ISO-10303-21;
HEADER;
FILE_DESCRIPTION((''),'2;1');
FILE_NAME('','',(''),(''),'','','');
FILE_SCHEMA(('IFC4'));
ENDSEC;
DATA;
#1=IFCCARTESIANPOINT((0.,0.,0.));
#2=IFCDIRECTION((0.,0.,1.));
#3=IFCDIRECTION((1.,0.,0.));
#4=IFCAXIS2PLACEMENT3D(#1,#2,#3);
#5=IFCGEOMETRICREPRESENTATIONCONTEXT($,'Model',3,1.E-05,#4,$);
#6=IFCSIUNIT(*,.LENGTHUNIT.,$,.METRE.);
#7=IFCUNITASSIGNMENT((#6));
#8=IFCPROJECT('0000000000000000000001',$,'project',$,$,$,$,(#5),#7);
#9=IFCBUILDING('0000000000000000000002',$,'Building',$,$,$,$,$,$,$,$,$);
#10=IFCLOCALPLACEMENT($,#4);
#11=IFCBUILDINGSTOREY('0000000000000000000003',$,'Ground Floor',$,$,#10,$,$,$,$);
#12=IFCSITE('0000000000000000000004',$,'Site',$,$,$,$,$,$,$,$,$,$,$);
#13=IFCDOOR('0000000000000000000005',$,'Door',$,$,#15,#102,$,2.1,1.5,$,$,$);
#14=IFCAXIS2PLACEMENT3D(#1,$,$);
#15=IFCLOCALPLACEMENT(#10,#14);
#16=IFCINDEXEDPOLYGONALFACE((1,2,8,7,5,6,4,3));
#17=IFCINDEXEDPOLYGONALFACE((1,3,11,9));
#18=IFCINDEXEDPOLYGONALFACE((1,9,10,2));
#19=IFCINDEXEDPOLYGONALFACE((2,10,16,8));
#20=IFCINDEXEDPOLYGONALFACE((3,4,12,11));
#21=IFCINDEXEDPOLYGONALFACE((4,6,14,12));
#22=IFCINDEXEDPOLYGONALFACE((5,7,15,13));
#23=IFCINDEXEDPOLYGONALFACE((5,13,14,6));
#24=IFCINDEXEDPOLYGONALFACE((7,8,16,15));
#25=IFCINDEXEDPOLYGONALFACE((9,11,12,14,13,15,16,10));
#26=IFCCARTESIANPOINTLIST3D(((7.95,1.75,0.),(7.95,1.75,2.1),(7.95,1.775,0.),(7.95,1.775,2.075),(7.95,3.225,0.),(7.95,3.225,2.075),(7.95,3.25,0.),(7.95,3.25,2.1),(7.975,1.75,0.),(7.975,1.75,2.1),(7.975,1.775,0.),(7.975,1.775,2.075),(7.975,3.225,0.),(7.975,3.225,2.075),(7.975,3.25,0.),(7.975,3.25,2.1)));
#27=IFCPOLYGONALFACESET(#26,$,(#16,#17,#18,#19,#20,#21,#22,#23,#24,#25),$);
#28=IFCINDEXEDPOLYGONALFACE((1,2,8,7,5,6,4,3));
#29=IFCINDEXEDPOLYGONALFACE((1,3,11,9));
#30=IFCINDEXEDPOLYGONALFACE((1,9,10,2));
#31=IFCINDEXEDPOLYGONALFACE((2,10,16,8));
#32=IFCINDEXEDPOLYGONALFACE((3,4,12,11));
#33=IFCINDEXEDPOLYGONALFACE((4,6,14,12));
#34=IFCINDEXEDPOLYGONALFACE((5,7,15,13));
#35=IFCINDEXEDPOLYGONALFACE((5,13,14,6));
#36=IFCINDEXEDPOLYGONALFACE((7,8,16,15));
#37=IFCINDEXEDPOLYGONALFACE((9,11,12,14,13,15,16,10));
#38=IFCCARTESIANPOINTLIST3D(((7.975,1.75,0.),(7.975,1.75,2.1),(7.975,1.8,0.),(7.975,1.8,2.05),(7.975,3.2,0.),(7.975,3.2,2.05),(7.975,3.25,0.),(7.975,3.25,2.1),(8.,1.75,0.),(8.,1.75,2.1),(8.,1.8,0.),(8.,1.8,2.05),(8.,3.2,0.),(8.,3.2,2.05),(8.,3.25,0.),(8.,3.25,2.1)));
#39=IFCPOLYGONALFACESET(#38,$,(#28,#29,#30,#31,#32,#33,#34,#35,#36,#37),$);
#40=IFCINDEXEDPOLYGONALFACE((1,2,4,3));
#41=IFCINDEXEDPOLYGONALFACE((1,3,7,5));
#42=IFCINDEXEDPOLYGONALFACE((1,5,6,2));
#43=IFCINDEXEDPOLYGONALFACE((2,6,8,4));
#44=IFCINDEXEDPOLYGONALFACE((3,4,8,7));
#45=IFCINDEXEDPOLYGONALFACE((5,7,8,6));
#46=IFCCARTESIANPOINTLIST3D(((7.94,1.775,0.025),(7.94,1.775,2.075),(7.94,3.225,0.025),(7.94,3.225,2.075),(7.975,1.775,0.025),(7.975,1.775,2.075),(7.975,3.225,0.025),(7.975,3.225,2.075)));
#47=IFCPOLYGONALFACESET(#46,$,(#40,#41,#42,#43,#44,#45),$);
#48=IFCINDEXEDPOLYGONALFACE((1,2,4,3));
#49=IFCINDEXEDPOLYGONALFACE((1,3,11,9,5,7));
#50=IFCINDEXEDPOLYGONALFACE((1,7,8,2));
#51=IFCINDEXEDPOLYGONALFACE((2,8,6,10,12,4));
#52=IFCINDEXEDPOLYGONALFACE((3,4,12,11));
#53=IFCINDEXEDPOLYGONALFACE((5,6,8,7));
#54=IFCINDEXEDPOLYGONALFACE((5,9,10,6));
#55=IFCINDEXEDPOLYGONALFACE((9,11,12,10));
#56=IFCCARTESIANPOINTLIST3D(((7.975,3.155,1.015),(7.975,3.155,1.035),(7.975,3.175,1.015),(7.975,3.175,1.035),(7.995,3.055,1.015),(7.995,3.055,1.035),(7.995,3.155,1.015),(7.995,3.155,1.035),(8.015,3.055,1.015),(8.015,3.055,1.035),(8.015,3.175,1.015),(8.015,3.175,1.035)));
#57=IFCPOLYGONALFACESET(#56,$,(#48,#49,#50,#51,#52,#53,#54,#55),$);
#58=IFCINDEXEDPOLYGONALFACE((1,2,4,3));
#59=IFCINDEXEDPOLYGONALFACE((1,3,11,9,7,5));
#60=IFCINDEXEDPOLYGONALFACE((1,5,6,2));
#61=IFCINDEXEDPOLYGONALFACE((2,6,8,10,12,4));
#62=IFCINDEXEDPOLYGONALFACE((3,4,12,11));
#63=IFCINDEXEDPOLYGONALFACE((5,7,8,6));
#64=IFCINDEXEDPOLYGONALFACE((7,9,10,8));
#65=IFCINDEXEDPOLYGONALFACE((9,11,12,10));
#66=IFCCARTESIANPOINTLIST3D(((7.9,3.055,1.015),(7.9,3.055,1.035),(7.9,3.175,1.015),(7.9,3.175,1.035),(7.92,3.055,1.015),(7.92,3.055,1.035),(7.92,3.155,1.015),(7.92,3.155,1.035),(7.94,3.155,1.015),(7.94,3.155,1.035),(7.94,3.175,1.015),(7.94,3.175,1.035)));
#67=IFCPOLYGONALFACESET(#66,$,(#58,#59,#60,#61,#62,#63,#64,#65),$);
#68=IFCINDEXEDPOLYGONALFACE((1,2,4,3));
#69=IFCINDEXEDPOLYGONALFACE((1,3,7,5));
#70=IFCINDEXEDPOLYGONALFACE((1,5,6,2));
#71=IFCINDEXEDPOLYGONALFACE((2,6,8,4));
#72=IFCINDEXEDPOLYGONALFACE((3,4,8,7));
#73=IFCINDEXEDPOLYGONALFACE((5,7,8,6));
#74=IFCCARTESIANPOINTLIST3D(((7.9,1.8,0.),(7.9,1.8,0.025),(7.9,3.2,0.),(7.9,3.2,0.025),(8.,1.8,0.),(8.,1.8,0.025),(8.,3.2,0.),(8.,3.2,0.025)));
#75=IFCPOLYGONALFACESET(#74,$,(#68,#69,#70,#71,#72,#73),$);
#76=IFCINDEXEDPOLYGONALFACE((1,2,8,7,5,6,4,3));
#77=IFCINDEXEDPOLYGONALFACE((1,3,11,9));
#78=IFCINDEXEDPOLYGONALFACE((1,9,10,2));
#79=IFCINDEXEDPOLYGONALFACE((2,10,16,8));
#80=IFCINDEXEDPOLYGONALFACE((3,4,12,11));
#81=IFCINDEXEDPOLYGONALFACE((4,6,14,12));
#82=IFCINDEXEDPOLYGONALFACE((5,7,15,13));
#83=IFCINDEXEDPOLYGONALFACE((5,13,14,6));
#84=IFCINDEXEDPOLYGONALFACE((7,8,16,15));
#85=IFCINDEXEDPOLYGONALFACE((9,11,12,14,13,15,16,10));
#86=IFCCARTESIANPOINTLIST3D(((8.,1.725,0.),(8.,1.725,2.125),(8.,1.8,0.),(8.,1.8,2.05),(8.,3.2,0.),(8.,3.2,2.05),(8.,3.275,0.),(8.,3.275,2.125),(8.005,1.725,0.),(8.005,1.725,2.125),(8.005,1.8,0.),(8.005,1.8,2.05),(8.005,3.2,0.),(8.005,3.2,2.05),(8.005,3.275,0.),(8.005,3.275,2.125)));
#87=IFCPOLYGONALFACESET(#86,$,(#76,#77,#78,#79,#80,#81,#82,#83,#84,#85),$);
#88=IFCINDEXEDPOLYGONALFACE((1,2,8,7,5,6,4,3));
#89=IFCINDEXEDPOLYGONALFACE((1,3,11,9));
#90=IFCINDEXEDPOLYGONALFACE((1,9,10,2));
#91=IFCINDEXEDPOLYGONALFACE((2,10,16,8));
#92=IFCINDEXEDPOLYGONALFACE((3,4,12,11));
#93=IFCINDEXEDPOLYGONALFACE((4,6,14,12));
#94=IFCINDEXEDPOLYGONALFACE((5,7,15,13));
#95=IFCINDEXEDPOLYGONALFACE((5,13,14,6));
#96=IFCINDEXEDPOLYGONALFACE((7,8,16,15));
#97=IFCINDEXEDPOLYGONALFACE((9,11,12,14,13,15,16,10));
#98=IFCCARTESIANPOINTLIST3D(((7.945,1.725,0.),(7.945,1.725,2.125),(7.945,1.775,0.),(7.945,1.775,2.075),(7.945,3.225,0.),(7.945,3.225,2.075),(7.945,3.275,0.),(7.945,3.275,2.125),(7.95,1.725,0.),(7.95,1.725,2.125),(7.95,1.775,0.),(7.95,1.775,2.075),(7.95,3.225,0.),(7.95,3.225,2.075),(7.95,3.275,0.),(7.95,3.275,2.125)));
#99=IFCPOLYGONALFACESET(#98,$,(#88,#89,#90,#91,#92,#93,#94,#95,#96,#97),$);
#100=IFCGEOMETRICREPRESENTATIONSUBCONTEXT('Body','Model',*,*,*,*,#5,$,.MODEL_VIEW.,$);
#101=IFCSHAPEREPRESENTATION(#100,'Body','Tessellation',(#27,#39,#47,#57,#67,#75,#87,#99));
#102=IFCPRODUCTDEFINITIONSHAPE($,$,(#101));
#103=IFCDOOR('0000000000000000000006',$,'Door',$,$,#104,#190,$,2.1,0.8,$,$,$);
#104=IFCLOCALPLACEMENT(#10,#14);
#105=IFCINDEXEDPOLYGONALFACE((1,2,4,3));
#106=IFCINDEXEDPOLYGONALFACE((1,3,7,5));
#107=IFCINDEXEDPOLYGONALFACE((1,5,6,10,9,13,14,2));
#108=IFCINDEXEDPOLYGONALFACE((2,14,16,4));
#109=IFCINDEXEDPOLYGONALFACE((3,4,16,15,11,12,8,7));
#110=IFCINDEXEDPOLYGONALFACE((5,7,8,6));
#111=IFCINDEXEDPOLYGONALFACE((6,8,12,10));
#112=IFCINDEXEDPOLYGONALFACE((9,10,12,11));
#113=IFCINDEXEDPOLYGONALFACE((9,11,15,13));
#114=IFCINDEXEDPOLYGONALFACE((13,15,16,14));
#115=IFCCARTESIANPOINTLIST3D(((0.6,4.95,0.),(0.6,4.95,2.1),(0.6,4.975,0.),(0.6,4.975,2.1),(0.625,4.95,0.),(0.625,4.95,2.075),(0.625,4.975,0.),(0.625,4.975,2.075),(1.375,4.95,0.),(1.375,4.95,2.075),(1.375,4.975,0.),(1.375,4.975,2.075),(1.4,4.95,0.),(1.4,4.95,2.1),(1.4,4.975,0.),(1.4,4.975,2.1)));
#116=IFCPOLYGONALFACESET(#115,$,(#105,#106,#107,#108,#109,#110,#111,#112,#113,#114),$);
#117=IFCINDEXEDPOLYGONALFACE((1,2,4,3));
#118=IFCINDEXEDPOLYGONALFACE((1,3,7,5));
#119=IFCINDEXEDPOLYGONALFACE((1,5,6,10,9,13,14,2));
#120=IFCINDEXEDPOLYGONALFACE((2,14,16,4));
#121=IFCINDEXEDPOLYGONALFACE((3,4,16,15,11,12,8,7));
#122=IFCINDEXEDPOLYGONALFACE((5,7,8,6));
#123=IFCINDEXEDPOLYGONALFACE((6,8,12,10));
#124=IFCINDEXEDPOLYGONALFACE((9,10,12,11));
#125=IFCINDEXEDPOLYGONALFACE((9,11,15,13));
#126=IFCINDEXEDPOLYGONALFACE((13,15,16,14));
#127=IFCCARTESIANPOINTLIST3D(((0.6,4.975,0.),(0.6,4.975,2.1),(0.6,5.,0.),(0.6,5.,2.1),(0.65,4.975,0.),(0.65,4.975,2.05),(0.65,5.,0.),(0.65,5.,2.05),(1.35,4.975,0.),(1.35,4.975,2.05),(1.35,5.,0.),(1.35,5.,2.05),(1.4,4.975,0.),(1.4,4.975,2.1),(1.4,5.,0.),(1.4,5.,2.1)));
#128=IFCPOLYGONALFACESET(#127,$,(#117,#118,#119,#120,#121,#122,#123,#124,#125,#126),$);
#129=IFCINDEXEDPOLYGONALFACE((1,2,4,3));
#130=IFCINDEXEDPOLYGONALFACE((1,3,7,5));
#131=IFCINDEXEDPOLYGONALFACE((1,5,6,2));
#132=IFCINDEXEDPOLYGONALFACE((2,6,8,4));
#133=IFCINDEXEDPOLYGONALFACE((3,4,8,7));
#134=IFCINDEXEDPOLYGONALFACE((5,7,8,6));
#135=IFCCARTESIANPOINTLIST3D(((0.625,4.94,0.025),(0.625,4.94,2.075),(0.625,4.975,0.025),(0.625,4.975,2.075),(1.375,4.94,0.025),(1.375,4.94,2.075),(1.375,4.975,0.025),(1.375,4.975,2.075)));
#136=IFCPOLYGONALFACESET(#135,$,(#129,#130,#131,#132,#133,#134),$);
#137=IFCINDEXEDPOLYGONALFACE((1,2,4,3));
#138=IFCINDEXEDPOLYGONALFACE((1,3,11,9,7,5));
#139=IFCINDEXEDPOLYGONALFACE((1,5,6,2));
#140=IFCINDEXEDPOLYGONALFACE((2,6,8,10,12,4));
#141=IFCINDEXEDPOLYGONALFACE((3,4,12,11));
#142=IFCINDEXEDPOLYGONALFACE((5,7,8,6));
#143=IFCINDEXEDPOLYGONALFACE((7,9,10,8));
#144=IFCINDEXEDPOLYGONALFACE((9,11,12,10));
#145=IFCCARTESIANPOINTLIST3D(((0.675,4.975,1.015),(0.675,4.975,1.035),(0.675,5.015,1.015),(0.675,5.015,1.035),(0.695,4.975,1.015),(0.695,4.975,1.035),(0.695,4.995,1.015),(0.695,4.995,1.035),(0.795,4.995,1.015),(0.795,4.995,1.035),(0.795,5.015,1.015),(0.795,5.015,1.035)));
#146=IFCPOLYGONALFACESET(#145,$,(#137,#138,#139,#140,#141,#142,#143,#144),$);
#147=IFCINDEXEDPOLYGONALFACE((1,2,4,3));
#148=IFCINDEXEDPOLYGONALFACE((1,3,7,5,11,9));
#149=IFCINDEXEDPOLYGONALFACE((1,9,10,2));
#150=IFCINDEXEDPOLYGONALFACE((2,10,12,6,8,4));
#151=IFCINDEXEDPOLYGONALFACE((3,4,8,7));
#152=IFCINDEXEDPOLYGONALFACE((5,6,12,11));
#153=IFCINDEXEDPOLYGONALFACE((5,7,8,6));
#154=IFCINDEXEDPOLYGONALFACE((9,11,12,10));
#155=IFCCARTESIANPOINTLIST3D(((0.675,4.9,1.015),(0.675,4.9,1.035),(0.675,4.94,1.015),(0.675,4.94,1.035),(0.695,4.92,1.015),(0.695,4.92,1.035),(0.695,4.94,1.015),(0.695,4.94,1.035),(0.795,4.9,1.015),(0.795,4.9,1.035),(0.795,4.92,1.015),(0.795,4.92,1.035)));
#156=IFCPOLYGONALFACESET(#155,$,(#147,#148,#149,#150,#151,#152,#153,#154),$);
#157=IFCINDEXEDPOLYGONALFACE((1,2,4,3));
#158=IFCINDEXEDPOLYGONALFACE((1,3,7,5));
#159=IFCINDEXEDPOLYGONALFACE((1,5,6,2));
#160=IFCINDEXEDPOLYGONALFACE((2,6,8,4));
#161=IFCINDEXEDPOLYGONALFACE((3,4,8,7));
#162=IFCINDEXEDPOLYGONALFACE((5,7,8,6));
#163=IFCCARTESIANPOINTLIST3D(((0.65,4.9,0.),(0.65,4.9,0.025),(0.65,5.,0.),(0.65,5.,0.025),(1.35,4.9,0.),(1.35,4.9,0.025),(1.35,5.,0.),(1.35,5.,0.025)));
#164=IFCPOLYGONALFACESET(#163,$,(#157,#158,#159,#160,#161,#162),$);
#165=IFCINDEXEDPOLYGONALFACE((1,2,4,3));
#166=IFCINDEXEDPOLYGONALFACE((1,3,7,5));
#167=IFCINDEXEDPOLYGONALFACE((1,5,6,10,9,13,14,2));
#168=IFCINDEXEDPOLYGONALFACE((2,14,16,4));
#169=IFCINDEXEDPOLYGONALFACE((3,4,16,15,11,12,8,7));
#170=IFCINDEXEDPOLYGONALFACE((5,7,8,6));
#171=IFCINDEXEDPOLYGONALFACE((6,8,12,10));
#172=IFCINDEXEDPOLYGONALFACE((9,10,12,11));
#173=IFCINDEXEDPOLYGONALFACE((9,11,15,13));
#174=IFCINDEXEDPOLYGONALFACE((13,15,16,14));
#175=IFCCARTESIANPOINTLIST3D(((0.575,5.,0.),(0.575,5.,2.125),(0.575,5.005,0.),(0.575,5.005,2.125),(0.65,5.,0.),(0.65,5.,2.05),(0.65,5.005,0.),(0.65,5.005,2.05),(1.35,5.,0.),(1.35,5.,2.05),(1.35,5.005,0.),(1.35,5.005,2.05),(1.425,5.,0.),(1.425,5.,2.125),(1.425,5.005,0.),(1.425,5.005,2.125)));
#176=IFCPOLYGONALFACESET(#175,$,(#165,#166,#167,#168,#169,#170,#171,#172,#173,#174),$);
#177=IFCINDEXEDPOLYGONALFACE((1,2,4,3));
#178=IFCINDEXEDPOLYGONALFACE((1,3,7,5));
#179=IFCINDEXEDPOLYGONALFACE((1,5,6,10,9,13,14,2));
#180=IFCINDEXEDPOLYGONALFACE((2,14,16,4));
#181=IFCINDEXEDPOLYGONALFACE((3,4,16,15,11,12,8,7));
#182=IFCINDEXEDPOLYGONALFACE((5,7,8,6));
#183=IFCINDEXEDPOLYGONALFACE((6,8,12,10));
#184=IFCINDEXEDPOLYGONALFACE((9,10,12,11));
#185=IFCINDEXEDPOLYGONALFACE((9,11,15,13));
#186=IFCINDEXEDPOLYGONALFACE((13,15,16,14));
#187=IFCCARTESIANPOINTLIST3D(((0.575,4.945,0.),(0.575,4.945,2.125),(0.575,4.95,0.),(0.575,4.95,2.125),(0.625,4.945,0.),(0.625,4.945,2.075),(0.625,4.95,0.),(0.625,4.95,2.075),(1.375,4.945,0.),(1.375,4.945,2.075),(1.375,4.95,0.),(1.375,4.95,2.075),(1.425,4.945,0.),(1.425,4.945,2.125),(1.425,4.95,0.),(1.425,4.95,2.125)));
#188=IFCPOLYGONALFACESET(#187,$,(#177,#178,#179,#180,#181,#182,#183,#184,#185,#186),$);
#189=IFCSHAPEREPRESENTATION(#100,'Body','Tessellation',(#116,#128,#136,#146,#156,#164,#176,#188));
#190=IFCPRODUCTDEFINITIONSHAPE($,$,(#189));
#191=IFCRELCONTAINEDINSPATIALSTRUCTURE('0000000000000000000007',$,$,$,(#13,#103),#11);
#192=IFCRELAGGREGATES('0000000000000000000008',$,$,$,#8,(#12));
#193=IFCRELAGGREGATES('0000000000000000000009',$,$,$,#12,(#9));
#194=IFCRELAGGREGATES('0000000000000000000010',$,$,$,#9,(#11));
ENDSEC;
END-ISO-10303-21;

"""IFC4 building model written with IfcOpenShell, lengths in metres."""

from ifc_helpers import new_model, si_unit, frame, origin_with_axes, place, context, subcontext, project, spatial, line, indexed_curve, outline, extrude, element, save


model = new_model("IFC4")

# Units and contexts
model_context = context("Model", 3, precision=1e-05, world=origin_with_axes())
body_context = subcontext(model_context, "Body", "Model", "MODEL_VIEW")
ifc_project = project(units=[si_unit("LENGTHUNIT", "METRE")], contexts=[model_context])

# Site, building, storey
site = spatial("IfcSite", under=ifc_project, Name="Site")
building = spatial("IfcBuilding", under=site, Name="Building")
storey_placement = place(None, origin_with_axes())
storey = spatial("IfcBuildingStorey", under=building, at=storey_placement, Name="Ground Floor")

# Doors
door_1_placement = place(storey_placement, frame((8.0, 1.75, 0.0), z_axis=(0.0, 0.0, 1.0), x_axis=(0.0, 1.0, 0.0)))
element("IfcDoor", 1, at=door_1_placement, inside=storey, Name="Door", OverallHeight=2.1, OverallWidth=1.5, context=body_context, shape_type="SweptSolid", body=[
    extrude(outline(indexed_curve([(0.0, 0.0), (0.0, 2.1), (1.5, 2.1), (1.5, 0.0), (1.475, 0.0), (1.475, 2.075), (0.025, 2.075), (0.025, 0.0)], segments=[line(1, 2, 3, 4, 5, 6, 7, 8, 1)])), frame((0.0, 0.025, 0.0), z_axis=(0.0, -1.0, 0.0), x_axis=(1.0, 0.0, 0.0)), (0.0, 0.0, -1.0), 0.025),
    extrude(outline(indexed_curve([(0.0, 0.0), (0.0, 2.1), (1.5, 2.1), (1.5, 0.0), (1.45, 0.0), (1.45, 2.05), (0.05, 2.05), (0.05, 0.0)], segments=[line(1, 2, 3, 4, 5, 6, 7, 8, 1)])), frame((0.0, 0.0, 0.0), z_axis=(0.0, -1.0, 0.0), x_axis=(1.0, 0.0, 0.0)), (0.0, 0.0, -1.0), 0.025),
    extrude(outline(indexed_curve([(0.0, 0.0), (1.45, 0.0), (1.45, 0.035), (0.0, 0.035)], segments=[line(1, 2, 3, 4, 1)])), frame((0.025, 0.025, 0.025), z_axis=(0.0, 0.0, 1.0), x_axis=(1.0, 0.0, 0.0)), (0.0, 0.0, 1.0), 2.05),
    extrude(outline(indexed_curve([(0.0, 0.0), (0.0, -0.04), (-0.12, -0.04), (-0.12, -0.02), (-0.02, -0.02), (-0.02, 0.0)], segments=[line(1, 2, 3, 4, 5, 6, 1)])), frame((1.425, 0.025, 1.015), z_axis=(0.0, 0.0, 1.0), x_axis=(1.0, 0.0, 0.0)), (0.0, 0.0, 1.0), 0.02),
    extrude(outline(indexed_curve([(0.0, 0.0), (0.0, 0.04), (-0.12, 0.04), (-0.12, 0.02), (-0.02, 0.02), (-0.02, 0.0)], segments=[line(1, 2, 3, 4, 5, 6, 1)])), frame((1.425, 0.06, 1.015), z_axis=(0.0, 0.0, 1.0), x_axis=(1.0, 0.0, 0.0)), (0.0, 0.0, 1.0), 0.02),
    extrude(outline(indexed_curve([(0.0, 0.0), (1.4, 0.0), (1.4, 0.1), (0.0, 0.1)], segments=[line(1, 2, 3, 4, 1)])), frame((0.05, 0.0, 0.0), z_axis=(0.0, 0.0, 1.0), x_axis=(1.0, 0.0, 0.0)), (0.0, 0.0, 1.0), 0.025),
    extrude(outline(indexed_curve([(0.0, 0.0), (0.0, 2.125), (1.55, 2.125), (1.55, 0.0), (1.475, 0.0), (1.475, 2.05), (0.075, 2.05), (0.075, 0.0)], segments=[line(1, 2, 3, 4, 5, 6, 7, 8, 1)])), frame((-0.025, -0.005, 0.0), z_axis=(0.0, -1.0, 0.0), x_axis=(1.0, 0.0, 0.0)), (0.0, 0.0, -1.0), 0.005),
    extrude(outline(indexed_curve([(0.0, 0.0), (0.0, 2.125), (1.55, 2.125), (1.55, 0.0), (1.5, 0.0), (1.5, 2.075), (0.05, 2.075), (0.05, 0.0)], segments=[line(1, 2, 3, 4, 5, 6, 7, 8, 1)])), frame((-0.025, 0.05, 0.0), z_axis=(0.0, -1.0, 0.0), x_axis=(1.0, 0.0, 0.0)), (0.0, 0.0, -1.0), 0.005),
])
door_2_placement = place(storey_placement, frame((1.4, 5.0, 0.0), z_axis=(0.0, 0.0, 1.0), x_axis=(-1.0, 0.0, 0.0)))
element("IfcDoor", 2, at=door_2_placement, inside=storey, Name="Door", OverallHeight=2.1, OverallWidth=0.8, context=body_context, shape_type="SweptSolid", body=[
    extrude(outline(indexed_curve([(0.0, 0.0), (0.0, 2.1), (0.8, 2.1), (0.8, 0.0), (0.775, 0.0), (0.775, 2.075), (0.025, 2.075), (0.025, 0.0)], segments=[line(1, 2, 3, 4, 5, 6, 7, 8, 1)])), frame((0.0, 0.025, 0.0), z_axis=(0.0, -1.0, 0.0), x_axis=(1.0, 0.0, 0.0)), (0.0, 0.0, -1.0), 0.025),
    extrude(outline(indexed_curve([(0.0, 0.0), (0.0, 2.1), (0.8, 2.1), (0.8, 0.0), (0.75, 0.0), (0.75, 2.05), (0.05, 2.05), (0.05, 0.0)], segments=[line(1, 2, 3, 4, 5, 6, 7, 8, 1)])), frame((0.0, 0.0, 0.0), z_axis=(0.0, -1.0, 0.0), x_axis=(1.0, 0.0, 0.0)), (0.0, 0.0, -1.0), 0.025),
    extrude(outline(indexed_curve([(0.0, 0.0), (0.75, 0.0), (0.75, 0.035), (0.0, 0.035)], segments=[line(1, 2, 3, 4, 1)])), frame((0.025, 0.025, 0.025), z_axis=(0.0, 0.0, 1.0), x_axis=(1.0, 0.0, 0.0)), (0.0, 0.0, 1.0), 2.05),
    extrude(outline(indexed_curve([(0.0, 0.0), (0.0, -0.04), (-0.12, -0.04), (-0.12, -0.02), (-0.02, -0.02), (-0.02, 0.0)], segments=[line(1, 2, 3, 4, 5, 6, 1)])), frame((0.725, 0.025, 1.015), z_axis=(0.0, 0.0, 1.0), x_axis=(1.0, 0.0, 0.0)), (0.0, 0.0, 1.0), 0.02),
    extrude(outline(indexed_curve([(0.0, 0.0), (0.0, 0.04), (-0.12, 0.04), (-0.12, 0.02), (-0.02, 0.02), (-0.02, 0.0)], segments=[line(1, 2, 3, 4, 5, 6, 1)])), frame((0.725, 0.06, 1.015), z_axis=(0.0, 0.0, 1.0), x_axis=(1.0, 0.0, 0.0)), (0.0, 0.0, 1.0), 0.02),
    extrude(outline(indexed_curve([(0.0, 0.0), (0.7, 0.0), (0.7, 0.1), (0.0, 0.1)], segments=[line(1, 2, 3, 4, 1)])), frame((0.05, 0.0, 0.0), z_axis=(0.0, 0.0, 1.0), x_axis=(1.0, 0.0, 0.0)), (0.0, 0.0, 1.0), 0.025),
    extrude(outline(indexed_curve([(0.0, 0.0), (0.0, 2.125), (0.85, 2.125), (0.85, 0.0), (0.775, 0.0), (0.775, 2.05), (0.075, 2.05), (0.075, 0.0)], segments=[line(1, 2, 3, 4, 5, 6, 7, 8, 1)])), frame((-0.025, -0.005, 0.0), z_axis=(0.0, -1.0, 0.0), x_axis=(1.0, 0.0, 0.0)), (0.0, 0.0, -1.0), 0.005),
    extrude(outline(indexed_curve([(0.0, 0.0), (0.0, 2.125), (0.85, 2.125), (0.85, 0.0), (0.8, 0.0), (0.8, 2.075), (0.05, 2.075), (0.05, 0.0)], segments=[line(1, 2, 3, 4, 5, 6, 7, 8, 1)])), frame((-0.025, 0.05, 0.0), z_axis=(0.0, -1.0, 0.0), x_axis=(1.0, 0.0, 0.0)), (0.0, 0.0, -1.0), 0.005),
])

save(model, "model.ifc")
